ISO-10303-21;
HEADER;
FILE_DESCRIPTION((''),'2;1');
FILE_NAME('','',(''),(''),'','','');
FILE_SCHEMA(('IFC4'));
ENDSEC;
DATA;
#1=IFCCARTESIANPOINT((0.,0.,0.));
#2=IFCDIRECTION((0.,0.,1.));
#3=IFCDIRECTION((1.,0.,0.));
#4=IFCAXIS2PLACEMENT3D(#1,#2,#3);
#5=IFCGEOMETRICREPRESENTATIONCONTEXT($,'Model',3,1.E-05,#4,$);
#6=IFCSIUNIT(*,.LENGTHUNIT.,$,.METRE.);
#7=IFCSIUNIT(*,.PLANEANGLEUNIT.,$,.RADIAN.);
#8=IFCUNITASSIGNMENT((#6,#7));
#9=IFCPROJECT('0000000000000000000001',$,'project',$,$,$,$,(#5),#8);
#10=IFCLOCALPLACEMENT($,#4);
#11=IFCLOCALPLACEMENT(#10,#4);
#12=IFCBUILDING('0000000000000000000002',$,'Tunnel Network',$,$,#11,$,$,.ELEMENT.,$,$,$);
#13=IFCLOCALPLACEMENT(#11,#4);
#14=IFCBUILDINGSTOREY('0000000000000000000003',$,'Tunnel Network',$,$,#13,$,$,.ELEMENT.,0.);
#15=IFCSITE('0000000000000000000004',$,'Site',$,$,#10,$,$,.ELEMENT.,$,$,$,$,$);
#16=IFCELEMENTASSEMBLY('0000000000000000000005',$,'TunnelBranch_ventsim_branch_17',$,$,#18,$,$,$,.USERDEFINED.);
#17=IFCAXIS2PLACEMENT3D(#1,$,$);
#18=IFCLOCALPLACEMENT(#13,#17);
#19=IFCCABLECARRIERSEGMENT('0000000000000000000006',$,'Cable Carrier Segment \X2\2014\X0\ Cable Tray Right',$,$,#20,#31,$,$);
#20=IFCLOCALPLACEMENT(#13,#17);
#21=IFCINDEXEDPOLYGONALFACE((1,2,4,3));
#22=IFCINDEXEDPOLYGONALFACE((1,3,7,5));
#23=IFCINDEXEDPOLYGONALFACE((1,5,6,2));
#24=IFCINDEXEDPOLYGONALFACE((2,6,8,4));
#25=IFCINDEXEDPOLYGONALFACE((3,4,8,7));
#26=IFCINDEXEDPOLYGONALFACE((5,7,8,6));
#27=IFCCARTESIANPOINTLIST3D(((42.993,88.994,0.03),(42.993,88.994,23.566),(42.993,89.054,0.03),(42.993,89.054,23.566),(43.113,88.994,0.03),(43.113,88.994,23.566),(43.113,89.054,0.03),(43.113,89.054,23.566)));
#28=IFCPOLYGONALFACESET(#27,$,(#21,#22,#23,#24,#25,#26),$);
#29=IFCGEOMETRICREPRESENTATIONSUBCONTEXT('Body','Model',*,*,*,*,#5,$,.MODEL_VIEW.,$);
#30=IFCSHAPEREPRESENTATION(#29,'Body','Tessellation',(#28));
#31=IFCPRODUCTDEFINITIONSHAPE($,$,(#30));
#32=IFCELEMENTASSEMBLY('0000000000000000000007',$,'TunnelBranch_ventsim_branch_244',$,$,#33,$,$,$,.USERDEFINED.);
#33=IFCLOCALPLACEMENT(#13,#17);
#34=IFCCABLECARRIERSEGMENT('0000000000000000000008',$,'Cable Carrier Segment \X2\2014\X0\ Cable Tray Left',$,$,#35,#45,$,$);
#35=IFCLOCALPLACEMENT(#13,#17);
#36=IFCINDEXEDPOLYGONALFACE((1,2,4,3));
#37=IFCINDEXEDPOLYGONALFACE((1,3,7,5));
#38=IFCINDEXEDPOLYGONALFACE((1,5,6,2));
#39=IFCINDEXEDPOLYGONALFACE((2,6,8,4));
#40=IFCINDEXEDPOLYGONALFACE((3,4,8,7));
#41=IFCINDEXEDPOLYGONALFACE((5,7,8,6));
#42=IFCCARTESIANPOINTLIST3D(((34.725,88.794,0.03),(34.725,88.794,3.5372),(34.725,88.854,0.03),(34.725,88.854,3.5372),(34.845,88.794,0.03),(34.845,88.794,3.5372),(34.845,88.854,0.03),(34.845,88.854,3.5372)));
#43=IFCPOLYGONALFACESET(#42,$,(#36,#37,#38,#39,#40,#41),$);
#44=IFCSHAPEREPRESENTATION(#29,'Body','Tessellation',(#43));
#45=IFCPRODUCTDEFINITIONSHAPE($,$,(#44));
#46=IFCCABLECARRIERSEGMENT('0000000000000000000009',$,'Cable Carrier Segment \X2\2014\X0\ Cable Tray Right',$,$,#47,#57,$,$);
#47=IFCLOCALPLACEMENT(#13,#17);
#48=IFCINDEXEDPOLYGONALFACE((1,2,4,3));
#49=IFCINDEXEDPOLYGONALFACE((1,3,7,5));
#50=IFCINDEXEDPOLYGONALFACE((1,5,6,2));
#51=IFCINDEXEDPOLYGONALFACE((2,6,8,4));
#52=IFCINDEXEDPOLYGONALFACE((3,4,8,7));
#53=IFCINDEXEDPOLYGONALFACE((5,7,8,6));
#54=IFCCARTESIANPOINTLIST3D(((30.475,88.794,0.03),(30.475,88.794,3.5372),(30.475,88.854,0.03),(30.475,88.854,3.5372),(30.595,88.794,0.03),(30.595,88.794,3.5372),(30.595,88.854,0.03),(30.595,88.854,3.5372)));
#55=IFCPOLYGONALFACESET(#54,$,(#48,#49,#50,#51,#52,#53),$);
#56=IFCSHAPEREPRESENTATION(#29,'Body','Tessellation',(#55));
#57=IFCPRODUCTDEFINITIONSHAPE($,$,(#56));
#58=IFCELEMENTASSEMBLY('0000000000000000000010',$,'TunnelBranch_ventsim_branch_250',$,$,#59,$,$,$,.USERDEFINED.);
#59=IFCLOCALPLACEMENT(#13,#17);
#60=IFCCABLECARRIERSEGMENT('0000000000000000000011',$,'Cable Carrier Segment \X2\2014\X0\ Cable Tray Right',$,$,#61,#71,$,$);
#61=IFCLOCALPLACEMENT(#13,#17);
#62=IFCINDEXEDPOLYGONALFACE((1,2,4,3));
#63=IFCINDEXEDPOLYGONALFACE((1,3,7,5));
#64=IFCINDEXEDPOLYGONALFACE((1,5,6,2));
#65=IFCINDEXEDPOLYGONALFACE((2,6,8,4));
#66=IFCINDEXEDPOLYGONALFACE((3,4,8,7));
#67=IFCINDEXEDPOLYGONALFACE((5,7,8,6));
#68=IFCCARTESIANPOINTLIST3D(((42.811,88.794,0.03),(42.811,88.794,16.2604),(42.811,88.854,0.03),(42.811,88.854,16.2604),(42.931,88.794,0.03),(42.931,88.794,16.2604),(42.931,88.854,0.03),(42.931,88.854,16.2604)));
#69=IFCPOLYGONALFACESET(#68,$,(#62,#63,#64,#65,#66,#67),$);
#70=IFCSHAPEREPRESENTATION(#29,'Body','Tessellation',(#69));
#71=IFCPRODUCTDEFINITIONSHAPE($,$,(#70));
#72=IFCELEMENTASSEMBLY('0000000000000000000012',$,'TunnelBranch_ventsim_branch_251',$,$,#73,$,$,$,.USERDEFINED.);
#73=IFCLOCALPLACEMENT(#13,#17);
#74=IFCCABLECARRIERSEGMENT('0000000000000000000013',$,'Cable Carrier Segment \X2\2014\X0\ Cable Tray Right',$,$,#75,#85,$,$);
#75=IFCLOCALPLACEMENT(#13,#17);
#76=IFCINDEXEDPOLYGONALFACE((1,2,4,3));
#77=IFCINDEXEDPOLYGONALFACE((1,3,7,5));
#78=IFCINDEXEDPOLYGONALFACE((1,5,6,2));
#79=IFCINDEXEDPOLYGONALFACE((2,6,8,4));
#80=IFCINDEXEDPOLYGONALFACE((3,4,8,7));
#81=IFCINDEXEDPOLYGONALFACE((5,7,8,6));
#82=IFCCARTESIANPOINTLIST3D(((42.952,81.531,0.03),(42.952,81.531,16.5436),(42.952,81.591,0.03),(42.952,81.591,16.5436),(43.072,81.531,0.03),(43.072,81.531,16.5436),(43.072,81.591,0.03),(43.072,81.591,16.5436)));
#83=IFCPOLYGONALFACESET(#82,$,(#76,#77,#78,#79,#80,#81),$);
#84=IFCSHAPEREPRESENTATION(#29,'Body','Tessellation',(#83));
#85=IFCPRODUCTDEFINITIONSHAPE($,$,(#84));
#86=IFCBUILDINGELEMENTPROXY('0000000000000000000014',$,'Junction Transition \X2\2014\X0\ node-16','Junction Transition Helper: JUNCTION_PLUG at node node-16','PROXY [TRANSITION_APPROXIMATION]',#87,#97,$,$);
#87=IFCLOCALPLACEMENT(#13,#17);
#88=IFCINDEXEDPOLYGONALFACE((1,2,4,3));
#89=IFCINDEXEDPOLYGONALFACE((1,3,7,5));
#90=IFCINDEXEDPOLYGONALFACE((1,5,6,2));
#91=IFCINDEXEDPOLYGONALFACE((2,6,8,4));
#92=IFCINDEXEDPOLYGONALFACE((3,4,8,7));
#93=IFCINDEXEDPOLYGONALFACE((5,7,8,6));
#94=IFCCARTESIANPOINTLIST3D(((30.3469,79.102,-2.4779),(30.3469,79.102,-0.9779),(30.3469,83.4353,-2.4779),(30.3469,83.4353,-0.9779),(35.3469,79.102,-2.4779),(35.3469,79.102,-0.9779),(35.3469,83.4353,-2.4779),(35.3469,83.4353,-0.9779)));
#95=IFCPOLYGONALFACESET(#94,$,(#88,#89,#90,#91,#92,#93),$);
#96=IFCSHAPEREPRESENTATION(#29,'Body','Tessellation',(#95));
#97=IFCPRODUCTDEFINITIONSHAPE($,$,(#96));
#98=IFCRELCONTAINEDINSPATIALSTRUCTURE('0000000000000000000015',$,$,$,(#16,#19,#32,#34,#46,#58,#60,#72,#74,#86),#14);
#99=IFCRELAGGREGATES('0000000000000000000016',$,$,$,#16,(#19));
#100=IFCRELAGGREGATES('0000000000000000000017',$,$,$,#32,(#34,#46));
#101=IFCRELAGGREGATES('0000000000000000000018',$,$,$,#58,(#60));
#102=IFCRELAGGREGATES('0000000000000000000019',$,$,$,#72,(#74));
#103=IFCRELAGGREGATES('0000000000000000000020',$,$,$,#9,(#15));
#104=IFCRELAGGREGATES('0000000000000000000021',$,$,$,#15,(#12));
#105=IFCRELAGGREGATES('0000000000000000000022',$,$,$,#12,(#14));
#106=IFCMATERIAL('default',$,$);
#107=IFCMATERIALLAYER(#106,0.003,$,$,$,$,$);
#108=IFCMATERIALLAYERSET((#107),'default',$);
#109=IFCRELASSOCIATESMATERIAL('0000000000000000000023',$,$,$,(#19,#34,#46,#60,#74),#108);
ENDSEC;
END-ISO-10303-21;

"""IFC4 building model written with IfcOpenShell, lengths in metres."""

from ifc_helpers import new_model, si_unit, frame, origin_with_axes, origin_2d_with_axis, place, context, subcontext, project, spatial, rectangle, extrude, material, layer, layer_set, layer_usage, element, aggregate, save


model = new_model("IFC4")

# Units and contexts
model_context = context("Model", 3, precision=1e-05, world=origin_with_axes())
body_context = subcontext(model_context, "Body", "Model", "MODEL_VIEW")
ifc_project = project(units=[si_unit("LENGTHUNIT", "METRE"), si_unit("PLANEANGLEUNIT", "RADIAN")], contexts=[model_context])

# Site, building, storey
site_placement = place(None, origin_with_axes())
site = spatial("IfcSite", under=ifc_project, at=site_placement, Name="Site", CompositionType="ELEMENT")
building_placement = place(site_placement, origin_with_axes())
building = spatial("IfcBuilding", under=site, at=building_placement, Name="Tunnel Network", CompositionType="ELEMENT")
storey_placement = place(building_placement, origin_with_axes())
storey = spatial("IfcBuildingStorey", under=building, at=storey_placement, Name="Tunnel Network", CompositionType="ELEMENT", Elevation=0.0)

# Shared definitions
ifc_material_1 = material(Name="default")
ifc_layer_1 = layer(ifc_material_1, 0.003)
ifc_layer_set_1 = layer_set([ifc_layer_1], Name="default")

# Element assembly, cable carrier segment
assembly_1_placement = place(storey_placement, frame((45.178, 90.149, 1.25), z_axis=(0.0, 1.0, 0.0), x_axis=(-1.0, 0.0, 0.0)))
assembly_1 = element("IfcElementAssembly", 1, at=assembly_1_placement, inside=storey, Name="TunnelBranch_ventsim_branch_17", PredefinedType="USERDEFINED")
ifc_layer_usage_1 = layer_usage(ifc_layer_set_1, "AXIS2", "POSITIVE", 0.0)
cable_carrier_segment_1_placement = place(storey_placement, frame((43.053, 89.024, 0.03), z_axis=(0.0, 0.0, 1.0), x_axis=(-1.0, 0.0, 0.0)))
cable_carrier_segment_1 = element("IfcCableCarrierSegment", 2, at=cable_carrier_segment_1_placement, inside=storey, material=ifc_layer_usage_1, Name="Cable Carrier Segment — Cable Tray Right", context=body_context, shape_type="SweptSolid", body=[
    extrude(rectangle(XDim=0.12, YDim=0.06, at=origin_2d_with_axis()), origin_with_axes(), (0.0, 0.0, 1.0), 23.536),
])
aggregate(assembly_1, [cable_carrier_segment_1])

# Element assembly, cable carrier segments
assembly_2_placement = place(storey_placement, frame((32.66, 89.724, 1.0), z_axis=(0.0, 1.0, 0.0), x_axis=(-1.0, 0.0, 0.0)))
assembly_2 = element("IfcElementAssembly", 3, at=assembly_2_placement, inside=storey, Name="TunnelBranch_ventsim_branch_244", PredefinedType="USERDEFINED")
ifc_layer_usage_2 = layer_usage(ifc_layer_set_1, "AXIS2", "POSITIVE", 0.0)
cable_carrier_segment_2_placement = place(storey_placement, frame((34.785, 88.824, 0.03), z_axis=(0.0, 0.0, 1.0), x_axis=(-1.0, 0.0, 0.0)))
cable_carrier_segment_2 = element("IfcCableCarrierSegment", 4, at=cable_carrier_segment_2_placement, inside=storey, material=ifc_layer_usage_2, Name="Cable Carrier Segment — Cable Tray Left", context=body_context, shape_type="SweptSolid", body=[
    extrude(rectangle(XDim=0.12, YDim=0.06, at=origin_2d_with_axis()), origin_with_axes(), (0.0, 0.0, 1.0), 3.5072),
])
ifc_layer_usage_3 = layer_usage(ifc_layer_set_1, "AXIS2", "POSITIVE", 0.0)
cable_carrier_segment_3_placement = place(storey_placement, frame((30.535, 88.824, 0.03), z_axis=(0.0, 0.0, 1.0), x_axis=(-1.0, 0.0, 0.0)))
cable_carrier_segment_3 = element("IfcCableCarrierSegment", 5, at=cable_carrier_segment_3_placement, inside=storey, material=ifc_layer_usage_3, Name="Cable Carrier Segment — Cable Tray Right", context=body_context, shape_type="SweptSolid", body=[
    extrude(rectangle(XDim=0.12, YDim=0.06, at=origin_2d_with_axis()), origin_with_axes(), (0.0, 0.0, 1.0), 3.5072),
])
aggregate(assembly_2, [cable_carrier_segment_2, cable_carrier_segment_3])

# Element assemblies, cable carrier segments
assembly_3_placement = place(storey_placement, frame((44.996, 89.724, 1.0), z_axis=(0.0, 1.0, 0.0), x_axis=(-1.0, 0.0, 0.0)))
assembly_3 = element("IfcElementAssembly", 6, at=assembly_3_placement, inside=storey, Name="TunnelBranch_ventsim_branch_250", PredefinedType="USERDEFINED")
ifc_layer_usage_4 = layer_usage(ifc_layer_set_1, "AXIS2", "POSITIVE", 0.0)
cable_carrier_segment_4_placement = place(storey_placement, frame((42.871, 88.824, 0.03), z_axis=(0.0, 0.0, 1.0), x_axis=(-1.0, 0.0, 0.0)))
cable_carrier_segment_4 = element("IfcCableCarrierSegment", 7, at=cable_carrier_segment_4_placement, inside=storey, material=ifc_layer_usage_4, Name="Cable Carrier Segment — Cable Tray Right", context=body_context, shape_type="SweptSolid", body=[
    extrude(rectangle(XDim=0.12, YDim=0.06, at=origin_2d_with_axis()), origin_with_axes(), (0.0, 0.0, 1.0), 16.2304),
])
aggregate(assembly_3, [cable_carrier_segment_4])
assembly_4_placement = place(storey_placement, frame((45.137, 82.461, 1.0), z_axis=(0.0, 1.0, 0.0), x_axis=(-1.0, 0.0, 0.0)))
assembly_4 = element("IfcElementAssembly", 8, at=assembly_4_placement, inside=storey, Name="TunnelBranch_ventsim_branch_251", PredefinedType="USERDEFINED")
ifc_layer_usage_5 = layer_usage(ifc_layer_set_1, "AXIS2", "POSITIVE", 0.0)
cable_carrier_segment_5_placement = place(storey_placement, frame((43.012, 81.561, 0.03), z_axis=(0.0, 0.0, 1.0), x_axis=(-1.0, 0.0, 0.0)))
cable_carrier_segment_5 = element("IfcCableCarrierSegment", 9, at=cable_carrier_segment_5_placement, inside=storey, material=ifc_layer_usage_5, Name="Cable Carrier Segment — Cable Tray Right", context=body_context, shape_type="SweptSolid", body=[
    extrude(rectangle(XDim=0.12, YDim=0.06, at=origin_2d_with_axis()), origin_with_axes(), (0.0, 0.0, 1.0), 16.5136),
])
aggregate(assembly_4, [cable_carrier_segment_5])

# Building element proxy
proxy_placement = place(storey_placement, frame((32.8469, 81.2687, -2.4779), z_axis=(0.0, 0.0, 1.0), x_axis=(1.0, 0.0, 0.0)))
element("IfcBuildingElementProxy", 10, at=proxy_placement, inside=storey, Name="Junction Transition — node-16", Description="Junction Transition Helper: JUNCTION_PLUG at node node-16", ObjectType="PROXY [TRANSITION_APPROXIMATION]", context=body_context, shape_type="SweptSolid", body=[
    extrude(rectangle(XDim=5.0, YDim=4.3333, at=origin_2d_with_axis()), origin_with_axes(), (0.0, 0.0, 1.0), 1.5),
])

save(model, "model.ifc")
